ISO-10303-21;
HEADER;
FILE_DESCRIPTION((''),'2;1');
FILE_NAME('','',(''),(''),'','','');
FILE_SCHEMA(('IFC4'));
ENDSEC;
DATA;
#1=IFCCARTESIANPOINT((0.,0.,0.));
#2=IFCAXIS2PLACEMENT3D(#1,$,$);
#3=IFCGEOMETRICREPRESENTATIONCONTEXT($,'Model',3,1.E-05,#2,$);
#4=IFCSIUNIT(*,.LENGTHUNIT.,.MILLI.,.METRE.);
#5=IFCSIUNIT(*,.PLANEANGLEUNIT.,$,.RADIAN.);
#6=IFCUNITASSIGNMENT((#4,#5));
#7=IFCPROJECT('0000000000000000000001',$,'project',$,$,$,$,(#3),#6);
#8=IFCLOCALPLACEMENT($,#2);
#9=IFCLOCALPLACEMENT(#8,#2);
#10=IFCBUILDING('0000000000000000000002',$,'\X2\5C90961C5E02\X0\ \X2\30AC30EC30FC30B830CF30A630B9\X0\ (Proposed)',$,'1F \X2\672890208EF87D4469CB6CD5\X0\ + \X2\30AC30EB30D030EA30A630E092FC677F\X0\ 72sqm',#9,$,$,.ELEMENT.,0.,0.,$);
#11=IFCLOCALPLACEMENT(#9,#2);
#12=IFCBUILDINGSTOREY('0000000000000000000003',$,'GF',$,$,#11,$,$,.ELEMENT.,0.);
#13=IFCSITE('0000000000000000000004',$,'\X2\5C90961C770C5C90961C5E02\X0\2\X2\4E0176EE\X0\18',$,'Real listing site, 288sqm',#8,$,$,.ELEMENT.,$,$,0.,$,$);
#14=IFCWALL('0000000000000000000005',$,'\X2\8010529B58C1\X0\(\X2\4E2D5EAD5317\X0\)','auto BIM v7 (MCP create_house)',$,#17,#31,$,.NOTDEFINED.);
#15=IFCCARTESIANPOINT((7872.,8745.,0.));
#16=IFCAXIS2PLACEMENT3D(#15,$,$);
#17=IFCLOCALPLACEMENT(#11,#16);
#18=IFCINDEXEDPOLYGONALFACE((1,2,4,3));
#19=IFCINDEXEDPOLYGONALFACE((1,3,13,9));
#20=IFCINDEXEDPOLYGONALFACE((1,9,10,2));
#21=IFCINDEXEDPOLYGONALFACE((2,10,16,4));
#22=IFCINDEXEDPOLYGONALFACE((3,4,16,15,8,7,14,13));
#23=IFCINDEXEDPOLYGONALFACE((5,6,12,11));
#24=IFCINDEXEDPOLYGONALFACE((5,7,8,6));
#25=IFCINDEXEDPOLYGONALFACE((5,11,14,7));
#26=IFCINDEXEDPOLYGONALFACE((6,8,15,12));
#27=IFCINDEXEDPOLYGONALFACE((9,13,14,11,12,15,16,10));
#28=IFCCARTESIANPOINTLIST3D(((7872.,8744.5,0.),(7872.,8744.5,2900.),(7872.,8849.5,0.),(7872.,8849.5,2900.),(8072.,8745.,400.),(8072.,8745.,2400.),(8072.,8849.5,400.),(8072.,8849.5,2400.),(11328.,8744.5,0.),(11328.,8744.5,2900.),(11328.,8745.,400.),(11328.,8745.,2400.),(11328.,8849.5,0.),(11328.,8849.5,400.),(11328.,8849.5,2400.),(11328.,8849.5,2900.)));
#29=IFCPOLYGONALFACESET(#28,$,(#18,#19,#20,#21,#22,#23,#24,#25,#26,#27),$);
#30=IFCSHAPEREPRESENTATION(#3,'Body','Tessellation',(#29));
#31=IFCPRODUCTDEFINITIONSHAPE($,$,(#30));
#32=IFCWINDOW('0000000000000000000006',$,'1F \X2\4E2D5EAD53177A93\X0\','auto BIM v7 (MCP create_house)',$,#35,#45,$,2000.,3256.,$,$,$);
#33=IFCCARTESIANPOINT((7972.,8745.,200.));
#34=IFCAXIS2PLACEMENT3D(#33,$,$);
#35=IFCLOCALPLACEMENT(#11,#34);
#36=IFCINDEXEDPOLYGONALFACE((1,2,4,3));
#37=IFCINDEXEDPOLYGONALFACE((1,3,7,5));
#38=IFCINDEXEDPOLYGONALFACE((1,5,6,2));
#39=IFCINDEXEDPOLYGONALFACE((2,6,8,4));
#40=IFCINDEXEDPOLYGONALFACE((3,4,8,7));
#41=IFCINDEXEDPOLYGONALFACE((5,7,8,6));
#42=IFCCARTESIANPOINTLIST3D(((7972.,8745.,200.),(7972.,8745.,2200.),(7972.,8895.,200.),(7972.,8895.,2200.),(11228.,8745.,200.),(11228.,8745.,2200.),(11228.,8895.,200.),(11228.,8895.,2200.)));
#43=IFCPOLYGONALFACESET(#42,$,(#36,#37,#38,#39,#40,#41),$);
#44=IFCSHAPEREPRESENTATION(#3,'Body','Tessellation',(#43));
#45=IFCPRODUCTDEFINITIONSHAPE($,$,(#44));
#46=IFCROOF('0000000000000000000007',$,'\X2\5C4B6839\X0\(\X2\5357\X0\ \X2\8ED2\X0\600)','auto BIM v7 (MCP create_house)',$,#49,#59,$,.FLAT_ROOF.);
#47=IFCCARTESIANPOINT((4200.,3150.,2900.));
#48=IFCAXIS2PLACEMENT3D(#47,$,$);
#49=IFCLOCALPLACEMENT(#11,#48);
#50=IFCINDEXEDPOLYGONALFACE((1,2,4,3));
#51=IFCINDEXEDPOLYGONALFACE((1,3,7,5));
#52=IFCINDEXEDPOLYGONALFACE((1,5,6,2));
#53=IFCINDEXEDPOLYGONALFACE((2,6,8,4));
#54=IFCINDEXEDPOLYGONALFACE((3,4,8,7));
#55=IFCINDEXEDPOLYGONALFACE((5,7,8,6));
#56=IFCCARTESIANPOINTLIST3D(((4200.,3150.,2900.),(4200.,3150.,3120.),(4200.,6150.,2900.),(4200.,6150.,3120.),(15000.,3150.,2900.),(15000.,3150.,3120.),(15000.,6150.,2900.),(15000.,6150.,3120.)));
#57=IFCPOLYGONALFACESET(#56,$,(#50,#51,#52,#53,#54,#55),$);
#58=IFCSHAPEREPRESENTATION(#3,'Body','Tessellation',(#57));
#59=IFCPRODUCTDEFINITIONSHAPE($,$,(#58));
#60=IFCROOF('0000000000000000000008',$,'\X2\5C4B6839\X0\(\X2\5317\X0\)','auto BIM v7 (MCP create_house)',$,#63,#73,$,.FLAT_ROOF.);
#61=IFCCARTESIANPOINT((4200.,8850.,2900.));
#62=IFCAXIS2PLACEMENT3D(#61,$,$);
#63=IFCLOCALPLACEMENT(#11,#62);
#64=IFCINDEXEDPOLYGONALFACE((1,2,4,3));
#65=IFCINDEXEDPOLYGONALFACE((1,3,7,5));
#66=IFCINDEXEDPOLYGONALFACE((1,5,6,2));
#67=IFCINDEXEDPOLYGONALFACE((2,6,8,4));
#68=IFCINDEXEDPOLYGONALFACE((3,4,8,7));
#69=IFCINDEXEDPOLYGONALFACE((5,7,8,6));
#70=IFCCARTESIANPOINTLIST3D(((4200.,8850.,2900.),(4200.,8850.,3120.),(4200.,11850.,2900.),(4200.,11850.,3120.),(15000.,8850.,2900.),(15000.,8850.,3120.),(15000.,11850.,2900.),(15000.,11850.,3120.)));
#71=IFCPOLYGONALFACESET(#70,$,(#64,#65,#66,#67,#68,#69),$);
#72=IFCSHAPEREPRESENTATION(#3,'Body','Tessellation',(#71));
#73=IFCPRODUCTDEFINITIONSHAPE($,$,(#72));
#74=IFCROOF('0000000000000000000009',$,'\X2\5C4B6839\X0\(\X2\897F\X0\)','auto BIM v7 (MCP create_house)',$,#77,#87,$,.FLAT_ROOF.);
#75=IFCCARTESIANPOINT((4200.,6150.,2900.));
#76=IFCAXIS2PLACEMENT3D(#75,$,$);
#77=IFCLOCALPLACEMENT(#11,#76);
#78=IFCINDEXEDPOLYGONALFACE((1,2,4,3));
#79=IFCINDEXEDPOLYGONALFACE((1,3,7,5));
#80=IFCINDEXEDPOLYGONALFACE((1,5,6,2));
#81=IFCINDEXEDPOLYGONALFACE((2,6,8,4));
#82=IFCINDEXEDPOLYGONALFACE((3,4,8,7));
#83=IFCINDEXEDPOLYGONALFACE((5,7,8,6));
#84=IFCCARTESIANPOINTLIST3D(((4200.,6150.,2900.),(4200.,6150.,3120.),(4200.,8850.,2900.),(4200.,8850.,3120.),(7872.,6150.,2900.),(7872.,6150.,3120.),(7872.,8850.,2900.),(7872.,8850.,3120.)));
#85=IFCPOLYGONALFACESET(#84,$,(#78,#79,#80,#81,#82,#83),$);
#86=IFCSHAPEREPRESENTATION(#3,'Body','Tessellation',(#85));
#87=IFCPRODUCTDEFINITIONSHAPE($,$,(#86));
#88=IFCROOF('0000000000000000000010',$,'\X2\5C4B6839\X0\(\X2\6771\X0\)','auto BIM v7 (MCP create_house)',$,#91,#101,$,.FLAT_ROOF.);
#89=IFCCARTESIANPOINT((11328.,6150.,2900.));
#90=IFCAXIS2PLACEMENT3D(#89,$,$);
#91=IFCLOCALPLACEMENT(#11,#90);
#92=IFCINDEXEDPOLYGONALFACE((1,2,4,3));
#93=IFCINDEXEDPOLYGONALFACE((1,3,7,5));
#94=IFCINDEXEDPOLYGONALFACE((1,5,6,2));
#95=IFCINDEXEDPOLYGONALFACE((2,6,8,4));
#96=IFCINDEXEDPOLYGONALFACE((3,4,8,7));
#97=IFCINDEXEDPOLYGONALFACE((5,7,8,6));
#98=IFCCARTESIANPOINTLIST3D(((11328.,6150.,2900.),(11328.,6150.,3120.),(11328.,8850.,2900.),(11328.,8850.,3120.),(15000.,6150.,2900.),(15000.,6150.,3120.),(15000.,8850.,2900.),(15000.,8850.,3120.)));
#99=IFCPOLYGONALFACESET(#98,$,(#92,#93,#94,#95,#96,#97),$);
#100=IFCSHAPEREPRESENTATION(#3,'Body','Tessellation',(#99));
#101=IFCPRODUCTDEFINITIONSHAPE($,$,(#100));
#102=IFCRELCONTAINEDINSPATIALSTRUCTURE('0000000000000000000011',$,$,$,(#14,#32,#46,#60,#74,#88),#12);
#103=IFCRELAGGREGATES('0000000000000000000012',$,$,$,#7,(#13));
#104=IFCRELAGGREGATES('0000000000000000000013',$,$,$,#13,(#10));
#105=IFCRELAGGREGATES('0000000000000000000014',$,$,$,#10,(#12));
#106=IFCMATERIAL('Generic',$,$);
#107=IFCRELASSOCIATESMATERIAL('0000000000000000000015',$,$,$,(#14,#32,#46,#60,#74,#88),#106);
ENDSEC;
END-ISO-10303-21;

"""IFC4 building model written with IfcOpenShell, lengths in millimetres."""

from ifc_helpers import new_model, si_unit, frame, frame_2d, origin, place, context, project, spatial, rectangle, extrude, material, element, fill, save


model = new_model("IFC4")

# Units and contexts
model_context = context("Model", 3, precision=1e-05, world=origin())
ifc_project = project(units=[si_unit("LENGTHUNIT", "METRE", prefix="MILLI"), si_unit("PLANEANGLEUNIT", "RADIAN")], contexts=[model_context])

# Site, building, storey
site_placement = place(None, origin())
site = spatial("IfcSite", under=ifc_project, at=site_placement, Name="岐阜県岐阜市2丁目18", ObjectType="Real listing site, 288sqm", CompositionType="ELEMENT", RefElevation=0.0)
building_placement = place(site_placement, origin())
building = spatial("IfcBuilding", under=site, at=building_placement, Name="岐阜市 ガレージハウス (Proposed)", ObjectType="1F 木造軸組構法 + ガルバリウム鋼板 72sqm", CompositionType="ELEMENT", ElevationOfRefHeight=0.0, ElevationOfTerrain=0.0)
storey_placement = place(building_placement, origin())
storey = spatial("IfcBuildingStorey", under=building, at=storey_placement, Name="GF", CompositionType="ELEMENT", Elevation=0.0)

# Shared definitions
ifc_material = material(Name="Generic")

# Wall, opening, window
wall_1_placement = place(storey_placement, frame((7872.0, 8745.0, 0.0)))
wall_1 = element("IfcWall", 1, at=wall_1_placement, inside=storey, material=ifc_material, Name="耐力壁(中庭北)", Description="auto BIM v7 (MCP create_house)", PredefinedType="NOTDEFINED", context=model_context, shape_type="SweptSolid", body=[
    extrude(rectangle(XDim=3456.0, YDim=105.0, at=frame_2d((1728.0, 52.0))), frame((7872.0, 8745.0, 0.0)), (0.0, 0.0, 1.0), 2900.0),
])
opening_1_placement = place(storey_placement, frame((7972.0, 8745.0, 200.0)))
opening_1 = element("IfcOpeningElement", 2, at=opening_1_placement, cuts=wall_1, PredefinedType="NOTDEFINED", context=model_context, shape_type="SweptSolid", body=[
    extrude(rectangle(XDim=3256.0, YDim=150.0, at=frame_2d((1628.0, 75.0))), frame((7972.0, 8745.0, 200.0)), (0.0, 0.0, 1.0), 2000.0),
])
window_1_placement = place(storey_placement, frame((7972.0, 8745.0, 200.0)))
window_1 = element("IfcWindow", 3, at=window_1_placement, inside=storey, material=ifc_material, Name="1F 中庭北窓", Description="auto BIM v7 (MCP create_house)", OverallHeight=2000.0, OverallWidth=3256.0, context=model_context, shape_type="SweptSolid", body=[
    extrude(rectangle(XDim=3256.0, YDim=150.0, at=frame_2d((1628.0, 75.0))), frame((7972.0, 8745.0, 200.0)), (0.0, 0.0, 1.0), 2000.0),
])
fill(opening_1, window_1)

# Roofs
roof_1_placement = place(storey_placement, frame((4200.0, 3150.0, 2900.0)))
element("IfcRoof", 4, at=roof_1_placement, inside=storey, material=ifc_material, Name="屋根(南 軒600)", Description="auto BIM v7 (MCP create_house)", PredefinedType="FLAT_ROOF", context=model_context, shape_type="SweptSolid", body=[
    extrude(rectangle(XDim=10800.0, YDim=3000.0, at=frame_2d((5400.0, 1500.0))), frame((4200.0, 3150.0, 2900.0)), (0.0, 0.0, 1.0), 220.0),
])
roof_2_placement = place(storey_placement, frame((4200.0, 8850.0, 2900.0)))
element("IfcRoof", 5, at=roof_2_placement, inside=storey, material=ifc_material, Name="屋根(北)", Description="auto BIM v7 (MCP create_house)", PredefinedType="FLAT_ROOF", context=model_context, shape_type="SweptSolid", body=[
    extrude(rectangle(XDim=10800.0, YDim=3000.0, at=frame_2d((5400.0, 1500.0))), frame((4200.0, 8850.0, 2900.0)), (0.0, 0.0, 1.0), 220.0),
])
roof_3_placement = place(storey_placement, frame((4200.0, 6150.0, 2900.0)))
element("IfcRoof", 6, at=roof_3_placement, inside=storey, material=ifc_material, Name="屋根(西)", Description="auto BIM v7 (MCP create_house)", PredefinedType="FLAT_ROOF", context=model_context, shape_type="SweptSolid", body=[
    extrude(rectangle(XDim=3672.0, YDim=2700.0, at=frame_2d((1836.0, 1350.0))), frame((4200.0, 6150.0, 2900.0)), (0.0, 0.0, 1.0), 220.0),
])
roof_4_placement = place(storey_placement, frame((11328.0, 6150.0, 2900.0)))
element("IfcRoof", 7, at=roof_4_placement, inside=storey, material=ifc_material, Name="屋根(東)", Description="auto BIM v7 (MCP create_house)", PredefinedType="FLAT_ROOF", context=model_context, shape_type="SweptSolid", body=[
    extrude(rectangle(XDim=3672.0, YDim=2700.0, at=frame_2d((1836.0, 1350.0))), frame((11328.0, 6150.0, 2900.0)), (0.0, 0.0, 1.0), 220.0),
])

save(model, "model.ifc")
